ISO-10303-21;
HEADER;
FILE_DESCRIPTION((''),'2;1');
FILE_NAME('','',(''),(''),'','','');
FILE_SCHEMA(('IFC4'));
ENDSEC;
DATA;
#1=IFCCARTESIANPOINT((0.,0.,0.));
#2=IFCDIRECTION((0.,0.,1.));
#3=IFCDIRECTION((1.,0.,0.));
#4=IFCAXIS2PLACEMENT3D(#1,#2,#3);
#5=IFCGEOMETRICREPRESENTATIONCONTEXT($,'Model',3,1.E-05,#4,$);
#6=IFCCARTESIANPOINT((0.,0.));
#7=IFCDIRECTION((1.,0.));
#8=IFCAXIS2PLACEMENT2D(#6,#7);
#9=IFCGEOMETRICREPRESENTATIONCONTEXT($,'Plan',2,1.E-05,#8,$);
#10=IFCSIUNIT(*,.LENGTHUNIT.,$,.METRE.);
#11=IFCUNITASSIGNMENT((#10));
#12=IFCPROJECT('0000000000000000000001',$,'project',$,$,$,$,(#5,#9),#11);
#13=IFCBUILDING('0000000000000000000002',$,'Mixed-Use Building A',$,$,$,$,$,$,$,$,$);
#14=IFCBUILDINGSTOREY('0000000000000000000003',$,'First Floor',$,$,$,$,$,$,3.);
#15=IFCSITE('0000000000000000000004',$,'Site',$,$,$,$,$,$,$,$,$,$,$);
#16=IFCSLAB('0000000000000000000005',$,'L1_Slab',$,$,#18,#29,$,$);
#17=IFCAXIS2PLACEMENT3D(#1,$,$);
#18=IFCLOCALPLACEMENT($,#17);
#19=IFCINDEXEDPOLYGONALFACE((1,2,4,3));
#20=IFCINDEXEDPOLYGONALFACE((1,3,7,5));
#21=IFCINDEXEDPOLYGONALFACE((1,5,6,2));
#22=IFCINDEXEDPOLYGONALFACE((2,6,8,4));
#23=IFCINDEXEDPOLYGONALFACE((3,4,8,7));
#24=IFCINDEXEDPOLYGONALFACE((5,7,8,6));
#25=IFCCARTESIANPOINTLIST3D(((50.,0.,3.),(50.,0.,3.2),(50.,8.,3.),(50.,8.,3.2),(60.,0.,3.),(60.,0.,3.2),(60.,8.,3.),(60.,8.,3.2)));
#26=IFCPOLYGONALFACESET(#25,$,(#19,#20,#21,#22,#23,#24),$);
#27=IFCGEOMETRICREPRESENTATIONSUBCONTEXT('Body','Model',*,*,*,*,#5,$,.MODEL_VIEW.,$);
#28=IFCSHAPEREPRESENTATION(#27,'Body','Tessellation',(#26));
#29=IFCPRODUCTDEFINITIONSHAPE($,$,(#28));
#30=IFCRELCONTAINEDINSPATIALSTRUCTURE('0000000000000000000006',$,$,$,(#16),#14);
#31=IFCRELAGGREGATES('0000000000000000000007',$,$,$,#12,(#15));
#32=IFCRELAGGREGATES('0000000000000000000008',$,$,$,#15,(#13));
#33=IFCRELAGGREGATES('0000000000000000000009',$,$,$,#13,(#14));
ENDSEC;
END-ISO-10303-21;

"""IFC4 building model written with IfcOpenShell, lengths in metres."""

from ifc_helpers import new_model, si_unit, frame, origin_with_axes, origin_2d_with_axis, place, context, subcontext, project, spatial, indexed_curve, outline, extrude, element, save


model = new_model("IFC4")

# Units and contexts
model_context = context("Model", 3, precision=1e-05, world=origin_with_axes())
plan_context = context("Plan", 2, precision=1e-05, world=origin_2d_with_axis())
body_context = subcontext(model_context, "Body", "Model", "MODEL_VIEW")
ifc_project = project(units=[si_unit("LENGTHUNIT", "METRE")], contexts=[model_context, plan_context])

# Site, building, storey
site = spatial("IfcSite", under=ifc_project, Name="Site")
building = spatial("IfcBuilding", under=site, Name="Mixed-Use Building A")
storey = spatial("IfcBuildingStorey", under=building, Name="First Floor", Elevation=3.0)

# Slab
slab_placement = place(None, frame((50.0, 0.0, 3.0), z_axis=(0.0, 0.0, 1.0), x_axis=(1.0, 0.0, 0.0)))
element("IfcSlab", 1, at=slab_placement, inside=storey, Name="L1_Slab", context=body_context, shape_type="SweptSolid", body=[
    extrude(outline(indexed_curve([(0.0, 0.0), (10.0, 0.0), (10.0, 8.0), (0.0, 8.0)])), None, (0.0, 0.0, 1.0), 0.2),
])

save(model, "model.ifc")
